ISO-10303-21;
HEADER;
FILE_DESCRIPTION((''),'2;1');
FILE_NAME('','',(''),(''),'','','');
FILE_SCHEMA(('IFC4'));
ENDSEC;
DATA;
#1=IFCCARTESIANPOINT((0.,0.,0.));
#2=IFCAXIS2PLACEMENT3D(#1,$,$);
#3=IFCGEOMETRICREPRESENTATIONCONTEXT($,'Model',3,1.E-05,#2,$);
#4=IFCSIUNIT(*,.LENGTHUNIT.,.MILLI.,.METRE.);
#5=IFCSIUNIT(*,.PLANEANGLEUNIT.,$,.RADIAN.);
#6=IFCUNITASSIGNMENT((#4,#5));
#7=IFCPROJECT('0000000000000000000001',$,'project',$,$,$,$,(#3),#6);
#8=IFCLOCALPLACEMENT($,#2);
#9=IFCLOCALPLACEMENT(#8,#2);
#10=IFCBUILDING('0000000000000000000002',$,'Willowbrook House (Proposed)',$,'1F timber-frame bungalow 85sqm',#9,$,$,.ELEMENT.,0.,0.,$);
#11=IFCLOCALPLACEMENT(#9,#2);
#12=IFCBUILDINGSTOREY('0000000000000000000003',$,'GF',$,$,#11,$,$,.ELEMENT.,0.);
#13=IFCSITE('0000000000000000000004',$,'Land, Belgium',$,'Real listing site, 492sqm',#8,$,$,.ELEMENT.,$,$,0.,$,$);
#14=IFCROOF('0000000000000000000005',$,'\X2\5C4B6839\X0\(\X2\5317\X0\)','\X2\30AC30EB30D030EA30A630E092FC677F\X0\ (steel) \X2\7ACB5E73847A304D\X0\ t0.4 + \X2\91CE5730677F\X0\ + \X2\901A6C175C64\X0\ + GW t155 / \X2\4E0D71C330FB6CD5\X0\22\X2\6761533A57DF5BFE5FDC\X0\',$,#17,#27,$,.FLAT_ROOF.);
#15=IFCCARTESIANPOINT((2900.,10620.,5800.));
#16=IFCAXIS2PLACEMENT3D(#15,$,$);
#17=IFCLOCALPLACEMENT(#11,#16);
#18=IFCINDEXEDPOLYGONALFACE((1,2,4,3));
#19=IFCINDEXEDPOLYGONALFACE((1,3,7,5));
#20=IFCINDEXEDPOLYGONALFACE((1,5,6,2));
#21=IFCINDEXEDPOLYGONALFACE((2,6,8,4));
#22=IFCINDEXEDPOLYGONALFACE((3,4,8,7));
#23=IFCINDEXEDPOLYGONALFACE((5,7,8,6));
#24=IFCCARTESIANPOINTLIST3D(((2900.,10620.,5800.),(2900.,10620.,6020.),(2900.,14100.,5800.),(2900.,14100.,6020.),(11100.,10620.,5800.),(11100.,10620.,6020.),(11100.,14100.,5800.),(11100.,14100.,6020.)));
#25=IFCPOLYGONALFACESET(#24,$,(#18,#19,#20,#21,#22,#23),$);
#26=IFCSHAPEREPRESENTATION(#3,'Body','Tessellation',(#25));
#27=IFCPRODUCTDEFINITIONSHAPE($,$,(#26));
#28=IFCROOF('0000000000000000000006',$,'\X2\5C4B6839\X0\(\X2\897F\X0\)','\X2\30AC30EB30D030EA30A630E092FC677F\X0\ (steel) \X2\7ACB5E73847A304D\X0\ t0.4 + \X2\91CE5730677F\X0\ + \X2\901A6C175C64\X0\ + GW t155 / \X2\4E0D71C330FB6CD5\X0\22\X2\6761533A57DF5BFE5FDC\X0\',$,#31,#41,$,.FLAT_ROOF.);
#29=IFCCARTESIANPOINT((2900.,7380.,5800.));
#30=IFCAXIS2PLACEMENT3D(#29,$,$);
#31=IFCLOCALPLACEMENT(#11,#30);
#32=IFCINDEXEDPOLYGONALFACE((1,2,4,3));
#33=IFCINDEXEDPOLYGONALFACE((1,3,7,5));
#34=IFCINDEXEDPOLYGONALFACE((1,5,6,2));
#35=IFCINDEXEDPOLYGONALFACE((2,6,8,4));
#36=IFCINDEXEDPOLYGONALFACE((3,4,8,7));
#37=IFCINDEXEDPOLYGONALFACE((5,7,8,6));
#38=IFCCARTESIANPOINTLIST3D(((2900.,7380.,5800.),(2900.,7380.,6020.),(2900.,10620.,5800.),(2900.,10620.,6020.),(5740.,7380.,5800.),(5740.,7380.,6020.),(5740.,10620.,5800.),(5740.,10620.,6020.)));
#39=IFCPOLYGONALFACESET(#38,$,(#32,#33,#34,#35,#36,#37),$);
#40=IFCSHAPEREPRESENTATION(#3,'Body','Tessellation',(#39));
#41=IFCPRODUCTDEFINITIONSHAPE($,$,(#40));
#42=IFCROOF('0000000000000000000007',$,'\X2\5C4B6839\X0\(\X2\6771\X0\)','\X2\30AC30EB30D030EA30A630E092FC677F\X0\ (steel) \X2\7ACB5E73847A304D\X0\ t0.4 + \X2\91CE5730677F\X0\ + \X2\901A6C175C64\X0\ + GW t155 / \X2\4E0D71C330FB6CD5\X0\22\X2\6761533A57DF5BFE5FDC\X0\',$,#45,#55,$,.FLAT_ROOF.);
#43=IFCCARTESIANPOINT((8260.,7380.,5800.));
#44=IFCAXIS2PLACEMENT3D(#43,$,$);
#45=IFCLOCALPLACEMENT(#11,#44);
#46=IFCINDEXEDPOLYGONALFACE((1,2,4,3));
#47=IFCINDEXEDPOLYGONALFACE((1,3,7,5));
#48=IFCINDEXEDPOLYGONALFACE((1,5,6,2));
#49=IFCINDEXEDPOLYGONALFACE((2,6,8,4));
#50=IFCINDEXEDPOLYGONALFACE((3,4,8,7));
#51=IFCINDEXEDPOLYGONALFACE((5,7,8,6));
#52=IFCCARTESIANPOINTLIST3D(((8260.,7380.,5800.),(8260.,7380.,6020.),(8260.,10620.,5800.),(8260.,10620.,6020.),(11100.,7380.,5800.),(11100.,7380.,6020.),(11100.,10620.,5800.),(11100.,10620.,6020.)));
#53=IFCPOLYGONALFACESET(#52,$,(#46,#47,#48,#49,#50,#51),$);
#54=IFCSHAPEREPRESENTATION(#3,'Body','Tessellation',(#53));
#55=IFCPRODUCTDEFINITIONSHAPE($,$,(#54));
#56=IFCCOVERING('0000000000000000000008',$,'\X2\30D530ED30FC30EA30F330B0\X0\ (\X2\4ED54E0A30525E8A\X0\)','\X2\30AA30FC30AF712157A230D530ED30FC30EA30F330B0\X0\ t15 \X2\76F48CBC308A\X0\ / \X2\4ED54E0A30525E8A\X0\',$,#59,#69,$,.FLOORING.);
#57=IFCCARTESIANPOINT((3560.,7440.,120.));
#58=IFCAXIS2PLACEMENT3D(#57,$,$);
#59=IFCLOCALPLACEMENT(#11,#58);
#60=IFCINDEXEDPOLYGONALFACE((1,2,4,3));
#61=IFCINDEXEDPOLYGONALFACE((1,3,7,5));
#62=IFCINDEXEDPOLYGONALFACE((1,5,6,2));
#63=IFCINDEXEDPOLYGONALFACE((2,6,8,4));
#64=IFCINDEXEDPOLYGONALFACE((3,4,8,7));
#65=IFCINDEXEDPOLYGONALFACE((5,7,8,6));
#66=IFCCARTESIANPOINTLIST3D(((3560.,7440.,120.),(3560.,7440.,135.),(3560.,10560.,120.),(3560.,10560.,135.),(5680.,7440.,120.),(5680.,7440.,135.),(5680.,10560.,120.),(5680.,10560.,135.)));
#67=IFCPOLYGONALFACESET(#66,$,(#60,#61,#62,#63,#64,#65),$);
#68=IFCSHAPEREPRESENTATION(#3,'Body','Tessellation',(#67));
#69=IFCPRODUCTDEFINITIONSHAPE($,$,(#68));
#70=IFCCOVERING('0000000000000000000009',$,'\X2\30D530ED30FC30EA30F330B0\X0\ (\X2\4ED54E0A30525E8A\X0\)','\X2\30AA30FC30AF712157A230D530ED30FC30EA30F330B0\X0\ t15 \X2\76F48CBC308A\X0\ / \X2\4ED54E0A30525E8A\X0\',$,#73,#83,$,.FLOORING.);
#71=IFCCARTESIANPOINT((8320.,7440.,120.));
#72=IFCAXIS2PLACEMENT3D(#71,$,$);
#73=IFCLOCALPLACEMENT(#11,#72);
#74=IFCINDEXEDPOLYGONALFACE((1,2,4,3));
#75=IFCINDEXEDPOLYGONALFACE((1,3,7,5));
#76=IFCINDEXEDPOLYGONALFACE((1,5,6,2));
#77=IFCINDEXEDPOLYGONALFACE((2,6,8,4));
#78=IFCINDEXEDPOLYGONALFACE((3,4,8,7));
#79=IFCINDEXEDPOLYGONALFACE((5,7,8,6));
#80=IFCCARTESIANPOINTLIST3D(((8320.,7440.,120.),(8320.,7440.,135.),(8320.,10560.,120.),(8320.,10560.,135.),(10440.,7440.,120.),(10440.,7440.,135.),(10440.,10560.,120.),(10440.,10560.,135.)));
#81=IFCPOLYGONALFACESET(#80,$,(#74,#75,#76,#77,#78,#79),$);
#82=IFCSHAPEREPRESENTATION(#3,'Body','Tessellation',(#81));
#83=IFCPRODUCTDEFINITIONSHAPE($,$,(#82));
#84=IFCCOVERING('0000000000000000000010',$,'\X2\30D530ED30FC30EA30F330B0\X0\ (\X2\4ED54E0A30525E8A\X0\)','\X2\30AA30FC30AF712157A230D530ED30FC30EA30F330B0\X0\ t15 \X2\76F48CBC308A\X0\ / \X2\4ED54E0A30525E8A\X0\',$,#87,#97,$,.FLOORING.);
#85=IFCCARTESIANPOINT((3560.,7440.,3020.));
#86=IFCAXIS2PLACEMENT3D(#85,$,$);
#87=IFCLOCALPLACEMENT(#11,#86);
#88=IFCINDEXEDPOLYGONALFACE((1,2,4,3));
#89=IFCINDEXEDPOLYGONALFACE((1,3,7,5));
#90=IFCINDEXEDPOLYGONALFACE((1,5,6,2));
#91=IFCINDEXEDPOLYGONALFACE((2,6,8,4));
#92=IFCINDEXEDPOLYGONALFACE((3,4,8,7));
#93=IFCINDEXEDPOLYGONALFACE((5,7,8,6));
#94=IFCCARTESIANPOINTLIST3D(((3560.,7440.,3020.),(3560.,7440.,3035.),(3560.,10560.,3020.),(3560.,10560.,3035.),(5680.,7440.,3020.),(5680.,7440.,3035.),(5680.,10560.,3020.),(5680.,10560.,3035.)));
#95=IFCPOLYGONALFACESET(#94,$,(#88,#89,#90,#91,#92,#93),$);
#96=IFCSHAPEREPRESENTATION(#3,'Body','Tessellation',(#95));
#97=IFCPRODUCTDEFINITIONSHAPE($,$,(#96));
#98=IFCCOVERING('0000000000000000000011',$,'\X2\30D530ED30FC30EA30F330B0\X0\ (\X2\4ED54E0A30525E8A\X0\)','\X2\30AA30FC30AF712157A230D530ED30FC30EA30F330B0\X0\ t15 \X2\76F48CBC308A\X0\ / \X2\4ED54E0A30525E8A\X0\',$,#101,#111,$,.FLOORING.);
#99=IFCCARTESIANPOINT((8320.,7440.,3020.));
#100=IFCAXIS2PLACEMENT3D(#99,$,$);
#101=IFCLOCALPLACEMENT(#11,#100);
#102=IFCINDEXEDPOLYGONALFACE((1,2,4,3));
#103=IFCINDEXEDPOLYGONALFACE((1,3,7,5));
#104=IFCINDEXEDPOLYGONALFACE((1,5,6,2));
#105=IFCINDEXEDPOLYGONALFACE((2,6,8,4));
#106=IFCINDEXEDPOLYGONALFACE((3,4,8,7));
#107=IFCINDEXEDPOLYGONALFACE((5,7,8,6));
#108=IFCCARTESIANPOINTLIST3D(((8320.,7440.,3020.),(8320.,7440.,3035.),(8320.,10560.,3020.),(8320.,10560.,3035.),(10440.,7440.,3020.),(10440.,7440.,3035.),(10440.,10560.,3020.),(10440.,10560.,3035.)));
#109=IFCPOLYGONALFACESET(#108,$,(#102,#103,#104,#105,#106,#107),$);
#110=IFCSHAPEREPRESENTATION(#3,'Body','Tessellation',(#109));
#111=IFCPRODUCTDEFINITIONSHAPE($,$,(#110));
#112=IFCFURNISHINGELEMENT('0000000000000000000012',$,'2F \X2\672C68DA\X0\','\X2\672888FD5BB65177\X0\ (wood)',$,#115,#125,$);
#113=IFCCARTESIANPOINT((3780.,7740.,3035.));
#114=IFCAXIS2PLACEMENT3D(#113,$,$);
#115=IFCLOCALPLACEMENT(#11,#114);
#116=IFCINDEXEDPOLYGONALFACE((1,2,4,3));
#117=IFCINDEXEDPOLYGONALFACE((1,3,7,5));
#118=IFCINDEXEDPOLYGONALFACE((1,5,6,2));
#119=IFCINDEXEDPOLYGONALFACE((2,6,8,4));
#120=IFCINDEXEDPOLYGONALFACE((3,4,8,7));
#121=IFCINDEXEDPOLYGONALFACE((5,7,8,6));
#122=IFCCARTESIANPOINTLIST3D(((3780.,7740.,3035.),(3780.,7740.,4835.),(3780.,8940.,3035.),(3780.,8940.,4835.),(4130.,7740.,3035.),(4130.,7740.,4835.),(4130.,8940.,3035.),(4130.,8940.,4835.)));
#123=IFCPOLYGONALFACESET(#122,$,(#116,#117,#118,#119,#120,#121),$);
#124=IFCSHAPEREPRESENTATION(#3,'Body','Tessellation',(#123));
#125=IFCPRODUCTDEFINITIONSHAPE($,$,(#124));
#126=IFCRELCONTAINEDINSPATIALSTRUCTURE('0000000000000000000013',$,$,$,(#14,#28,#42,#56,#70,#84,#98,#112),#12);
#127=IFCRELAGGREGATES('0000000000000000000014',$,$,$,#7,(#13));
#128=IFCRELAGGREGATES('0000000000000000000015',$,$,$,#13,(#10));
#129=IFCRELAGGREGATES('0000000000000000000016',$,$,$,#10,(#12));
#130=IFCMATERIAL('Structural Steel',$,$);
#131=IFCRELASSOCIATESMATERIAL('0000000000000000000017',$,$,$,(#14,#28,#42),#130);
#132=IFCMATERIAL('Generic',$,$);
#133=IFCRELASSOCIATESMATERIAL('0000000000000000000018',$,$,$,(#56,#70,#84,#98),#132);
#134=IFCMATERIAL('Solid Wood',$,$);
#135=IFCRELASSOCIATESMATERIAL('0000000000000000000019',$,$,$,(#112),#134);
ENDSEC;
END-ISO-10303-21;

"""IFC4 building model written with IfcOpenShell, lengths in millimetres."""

from ifc_helpers import new_model, si_unit, frame, frame_2d, origin, place, context, project, spatial, rectangle, extrude, material, element, save


model = new_model("IFC4")

# Units and contexts
model_context = context("Model", 3, precision=1e-05, world=origin())
ifc_project = project(units=[si_unit("LENGTHUNIT", "METRE", prefix="MILLI"), si_unit("PLANEANGLEUNIT", "RADIAN")], contexts=[model_context])

# Site, building, storey
site_placement = place(None, origin())
site = spatial("IfcSite", under=ifc_project, at=site_placement, Name="Land, Belgium", ObjectType="Real listing site, 492sqm", CompositionType="ELEMENT", RefElevation=0.0)
building_placement = place(site_placement, origin())
building = spatial("IfcBuilding", under=site, at=building_placement, Name="Willowbrook House (Proposed)", ObjectType="1F timber-frame bungalow 85sqm", CompositionType="ELEMENT", ElevationOfRefHeight=0.0, ElevationOfTerrain=0.0)
storey_placement = place(building_placement, origin())
storey = spatial("IfcBuildingStorey", under=building, at=storey_placement, Name="GF", CompositionType="ELEMENT", Elevation=0.0)

# Shared definitions
ifc_material_1 = material(Name="Solid Wood")

# Shared definitions
ifc_material_2 = material(Name="Generic")

# Roofs
ifc_material_3 = material(Name="Structural Steel")
roof_1_placement = place(storey_placement, frame((2900.0, 10620.0, 5800.0)))
element("IfcRoof", 1, at=roof_1_placement, inside=storey, material=ifc_material_3, Name="屋根(北)", Description="ガルバリウム鋼板 (steel) 立平葺き t0.4 + 野地板 + 通気層 + GW t155 / 不燃・法22条区域対応", PredefinedType="FLAT_ROOF", context=model_context, shape_type="SweptSolid", body=[
    extrude(rectangle(XDim=8200.0, YDim=3480.0, at=frame_2d((4100.0, 1740.0))), frame((2900.0, 10620.0, 5800.0)), (0.0, 0.0, 1.0), 220.0),
])
roof_2_placement = place(storey_placement, frame((2900.0, 7380.0, 5800.0)))
element("IfcRoof", 2, at=roof_2_placement, inside=storey, material=ifc_material_3, Name="屋根(西)", Description="ガルバリウム鋼板 (steel) 立平葺き t0.4 + 野地板 + 通気層 + GW t155 / 不燃・法22条区域対応", PredefinedType="FLAT_ROOF", context=model_context, shape_type="SweptSolid", body=[
    extrude(rectangle(XDim=2840.0, YDim=3240.0, at=frame_2d((1420.0, 1620.0))), frame((2900.0, 7380.0, 5800.0)), (0.0, 0.0, 1.0), 220.0),
])
roof_3_placement = place(storey_placement, frame((8260.0, 7380.0, 5800.0)))
element("IfcRoof", 3, at=roof_3_placement, inside=storey, material=ifc_material_3, Name="屋根(東)", Description="ガルバリウム鋼板 (steel) 立平葺き t0.4 + 野地板 + 通気層 + GW t155 / 不燃・法22条区域対応", PredefinedType="FLAT_ROOF", context=model_context, shape_type="SweptSolid", body=[
    extrude(rectangle(XDim=2840.0, YDim=3240.0, at=frame_2d((1420.0, 1620.0))), frame((8260.0, 7380.0, 5800.0)), (0.0, 0.0, 1.0), 220.0),
])

# Coverings
covering_1_placement = place(storey_placement, frame((3560.0, 7440.0, 120.0)))
element("IfcCovering", 4, at=covering_1_placement, inside=storey, material=ifc_material_2, Name="フローリング (仕上げ床)", Description="オーク無垢フローリング t15 直貼り / 仕上げ床", PredefinedType="FLOORING", context=model_context, shape_type="SweptSolid", body=[
    extrude(rectangle(XDim=2120.0, YDim=3120.0, at=frame_2d((1060.0, 1560.0))), frame((3560.0, 7440.0, 120.0)), (0.0, 0.0, 1.0), 15.0),
])
covering_2_placement = place(storey_placement, frame((8320.0, 7440.0, 120.0)))
element("IfcCovering", 5, at=covering_2_placement, inside=storey, material=ifc_material_2, Name="フローリング (仕上げ床)", Description="オーク無垢フローリング t15 直貼り / 仕上げ床", PredefinedType="FLOORING", context=model_context, shape_type="SweptSolid", body=[
    extrude(rectangle(XDim=2120.0, YDim=3120.0, at=frame_2d((1060.0, 1560.0))), frame((8320.0, 7440.0, 120.0)), (0.0, 0.0, 1.0), 15.0),
])
covering_3_placement = place(storey_placement, frame((3560.0, 7440.0, 3020.0)))
element("IfcCovering", 6, at=covering_3_placement, inside=storey, material=ifc_material_2, Name="フローリング (仕上げ床)", Description="オーク無垢フローリング t15 直貼り / 仕上げ床", PredefinedType="FLOORING", context=model_context, shape_type="SweptSolid", body=[
    extrude(rectangle(XDim=2120.0, YDim=3120.0, at=frame_2d((1060.0, 1560.0))), frame((3560.0, 7440.0, 3020.0)), (0.0, 0.0, 1.0), 15.0),
])
covering_4_placement = place(storey_placement, frame((8320.0, 7440.0, 3020.0)))
element("IfcCovering", 7, at=covering_4_placement, inside=storey, material=ifc_material_2, Name="フローリング (仕上げ床)", Description="オーク無垢フローリング t15 直貼り / 仕上げ床", PredefinedType="FLOORING", context=model_context, shape_type="SweptSolid", body=[
    extrude(rectangle(XDim=2120.0, YDim=3120.0, at=frame_2d((1060.0, 1560.0))), frame((8320.0, 7440.0, 3020.0)), (0.0, 0.0, 1.0), 15.0),
])

# Furnishing element
furnishing_placement = place(storey_placement, frame((3780.0, 7740.0, 3035.0)))
element("IfcFurnishingElement", 8, at=furnishing_placement, inside=storey, material=ifc_material_1, Name="2F 本棚", Description="木製家具 (wood)", context=model_context, shape_type="SweptSolid", body=[
    extrude(rectangle(XDim=350.0, YDim=1200.0, at=frame_2d((175.0, 600.0))), frame((3780.0, 7740.0, 3035.0)), (0.0, 0.0, 1.0), 1800.0),
])

save(model, "model.ifc")
